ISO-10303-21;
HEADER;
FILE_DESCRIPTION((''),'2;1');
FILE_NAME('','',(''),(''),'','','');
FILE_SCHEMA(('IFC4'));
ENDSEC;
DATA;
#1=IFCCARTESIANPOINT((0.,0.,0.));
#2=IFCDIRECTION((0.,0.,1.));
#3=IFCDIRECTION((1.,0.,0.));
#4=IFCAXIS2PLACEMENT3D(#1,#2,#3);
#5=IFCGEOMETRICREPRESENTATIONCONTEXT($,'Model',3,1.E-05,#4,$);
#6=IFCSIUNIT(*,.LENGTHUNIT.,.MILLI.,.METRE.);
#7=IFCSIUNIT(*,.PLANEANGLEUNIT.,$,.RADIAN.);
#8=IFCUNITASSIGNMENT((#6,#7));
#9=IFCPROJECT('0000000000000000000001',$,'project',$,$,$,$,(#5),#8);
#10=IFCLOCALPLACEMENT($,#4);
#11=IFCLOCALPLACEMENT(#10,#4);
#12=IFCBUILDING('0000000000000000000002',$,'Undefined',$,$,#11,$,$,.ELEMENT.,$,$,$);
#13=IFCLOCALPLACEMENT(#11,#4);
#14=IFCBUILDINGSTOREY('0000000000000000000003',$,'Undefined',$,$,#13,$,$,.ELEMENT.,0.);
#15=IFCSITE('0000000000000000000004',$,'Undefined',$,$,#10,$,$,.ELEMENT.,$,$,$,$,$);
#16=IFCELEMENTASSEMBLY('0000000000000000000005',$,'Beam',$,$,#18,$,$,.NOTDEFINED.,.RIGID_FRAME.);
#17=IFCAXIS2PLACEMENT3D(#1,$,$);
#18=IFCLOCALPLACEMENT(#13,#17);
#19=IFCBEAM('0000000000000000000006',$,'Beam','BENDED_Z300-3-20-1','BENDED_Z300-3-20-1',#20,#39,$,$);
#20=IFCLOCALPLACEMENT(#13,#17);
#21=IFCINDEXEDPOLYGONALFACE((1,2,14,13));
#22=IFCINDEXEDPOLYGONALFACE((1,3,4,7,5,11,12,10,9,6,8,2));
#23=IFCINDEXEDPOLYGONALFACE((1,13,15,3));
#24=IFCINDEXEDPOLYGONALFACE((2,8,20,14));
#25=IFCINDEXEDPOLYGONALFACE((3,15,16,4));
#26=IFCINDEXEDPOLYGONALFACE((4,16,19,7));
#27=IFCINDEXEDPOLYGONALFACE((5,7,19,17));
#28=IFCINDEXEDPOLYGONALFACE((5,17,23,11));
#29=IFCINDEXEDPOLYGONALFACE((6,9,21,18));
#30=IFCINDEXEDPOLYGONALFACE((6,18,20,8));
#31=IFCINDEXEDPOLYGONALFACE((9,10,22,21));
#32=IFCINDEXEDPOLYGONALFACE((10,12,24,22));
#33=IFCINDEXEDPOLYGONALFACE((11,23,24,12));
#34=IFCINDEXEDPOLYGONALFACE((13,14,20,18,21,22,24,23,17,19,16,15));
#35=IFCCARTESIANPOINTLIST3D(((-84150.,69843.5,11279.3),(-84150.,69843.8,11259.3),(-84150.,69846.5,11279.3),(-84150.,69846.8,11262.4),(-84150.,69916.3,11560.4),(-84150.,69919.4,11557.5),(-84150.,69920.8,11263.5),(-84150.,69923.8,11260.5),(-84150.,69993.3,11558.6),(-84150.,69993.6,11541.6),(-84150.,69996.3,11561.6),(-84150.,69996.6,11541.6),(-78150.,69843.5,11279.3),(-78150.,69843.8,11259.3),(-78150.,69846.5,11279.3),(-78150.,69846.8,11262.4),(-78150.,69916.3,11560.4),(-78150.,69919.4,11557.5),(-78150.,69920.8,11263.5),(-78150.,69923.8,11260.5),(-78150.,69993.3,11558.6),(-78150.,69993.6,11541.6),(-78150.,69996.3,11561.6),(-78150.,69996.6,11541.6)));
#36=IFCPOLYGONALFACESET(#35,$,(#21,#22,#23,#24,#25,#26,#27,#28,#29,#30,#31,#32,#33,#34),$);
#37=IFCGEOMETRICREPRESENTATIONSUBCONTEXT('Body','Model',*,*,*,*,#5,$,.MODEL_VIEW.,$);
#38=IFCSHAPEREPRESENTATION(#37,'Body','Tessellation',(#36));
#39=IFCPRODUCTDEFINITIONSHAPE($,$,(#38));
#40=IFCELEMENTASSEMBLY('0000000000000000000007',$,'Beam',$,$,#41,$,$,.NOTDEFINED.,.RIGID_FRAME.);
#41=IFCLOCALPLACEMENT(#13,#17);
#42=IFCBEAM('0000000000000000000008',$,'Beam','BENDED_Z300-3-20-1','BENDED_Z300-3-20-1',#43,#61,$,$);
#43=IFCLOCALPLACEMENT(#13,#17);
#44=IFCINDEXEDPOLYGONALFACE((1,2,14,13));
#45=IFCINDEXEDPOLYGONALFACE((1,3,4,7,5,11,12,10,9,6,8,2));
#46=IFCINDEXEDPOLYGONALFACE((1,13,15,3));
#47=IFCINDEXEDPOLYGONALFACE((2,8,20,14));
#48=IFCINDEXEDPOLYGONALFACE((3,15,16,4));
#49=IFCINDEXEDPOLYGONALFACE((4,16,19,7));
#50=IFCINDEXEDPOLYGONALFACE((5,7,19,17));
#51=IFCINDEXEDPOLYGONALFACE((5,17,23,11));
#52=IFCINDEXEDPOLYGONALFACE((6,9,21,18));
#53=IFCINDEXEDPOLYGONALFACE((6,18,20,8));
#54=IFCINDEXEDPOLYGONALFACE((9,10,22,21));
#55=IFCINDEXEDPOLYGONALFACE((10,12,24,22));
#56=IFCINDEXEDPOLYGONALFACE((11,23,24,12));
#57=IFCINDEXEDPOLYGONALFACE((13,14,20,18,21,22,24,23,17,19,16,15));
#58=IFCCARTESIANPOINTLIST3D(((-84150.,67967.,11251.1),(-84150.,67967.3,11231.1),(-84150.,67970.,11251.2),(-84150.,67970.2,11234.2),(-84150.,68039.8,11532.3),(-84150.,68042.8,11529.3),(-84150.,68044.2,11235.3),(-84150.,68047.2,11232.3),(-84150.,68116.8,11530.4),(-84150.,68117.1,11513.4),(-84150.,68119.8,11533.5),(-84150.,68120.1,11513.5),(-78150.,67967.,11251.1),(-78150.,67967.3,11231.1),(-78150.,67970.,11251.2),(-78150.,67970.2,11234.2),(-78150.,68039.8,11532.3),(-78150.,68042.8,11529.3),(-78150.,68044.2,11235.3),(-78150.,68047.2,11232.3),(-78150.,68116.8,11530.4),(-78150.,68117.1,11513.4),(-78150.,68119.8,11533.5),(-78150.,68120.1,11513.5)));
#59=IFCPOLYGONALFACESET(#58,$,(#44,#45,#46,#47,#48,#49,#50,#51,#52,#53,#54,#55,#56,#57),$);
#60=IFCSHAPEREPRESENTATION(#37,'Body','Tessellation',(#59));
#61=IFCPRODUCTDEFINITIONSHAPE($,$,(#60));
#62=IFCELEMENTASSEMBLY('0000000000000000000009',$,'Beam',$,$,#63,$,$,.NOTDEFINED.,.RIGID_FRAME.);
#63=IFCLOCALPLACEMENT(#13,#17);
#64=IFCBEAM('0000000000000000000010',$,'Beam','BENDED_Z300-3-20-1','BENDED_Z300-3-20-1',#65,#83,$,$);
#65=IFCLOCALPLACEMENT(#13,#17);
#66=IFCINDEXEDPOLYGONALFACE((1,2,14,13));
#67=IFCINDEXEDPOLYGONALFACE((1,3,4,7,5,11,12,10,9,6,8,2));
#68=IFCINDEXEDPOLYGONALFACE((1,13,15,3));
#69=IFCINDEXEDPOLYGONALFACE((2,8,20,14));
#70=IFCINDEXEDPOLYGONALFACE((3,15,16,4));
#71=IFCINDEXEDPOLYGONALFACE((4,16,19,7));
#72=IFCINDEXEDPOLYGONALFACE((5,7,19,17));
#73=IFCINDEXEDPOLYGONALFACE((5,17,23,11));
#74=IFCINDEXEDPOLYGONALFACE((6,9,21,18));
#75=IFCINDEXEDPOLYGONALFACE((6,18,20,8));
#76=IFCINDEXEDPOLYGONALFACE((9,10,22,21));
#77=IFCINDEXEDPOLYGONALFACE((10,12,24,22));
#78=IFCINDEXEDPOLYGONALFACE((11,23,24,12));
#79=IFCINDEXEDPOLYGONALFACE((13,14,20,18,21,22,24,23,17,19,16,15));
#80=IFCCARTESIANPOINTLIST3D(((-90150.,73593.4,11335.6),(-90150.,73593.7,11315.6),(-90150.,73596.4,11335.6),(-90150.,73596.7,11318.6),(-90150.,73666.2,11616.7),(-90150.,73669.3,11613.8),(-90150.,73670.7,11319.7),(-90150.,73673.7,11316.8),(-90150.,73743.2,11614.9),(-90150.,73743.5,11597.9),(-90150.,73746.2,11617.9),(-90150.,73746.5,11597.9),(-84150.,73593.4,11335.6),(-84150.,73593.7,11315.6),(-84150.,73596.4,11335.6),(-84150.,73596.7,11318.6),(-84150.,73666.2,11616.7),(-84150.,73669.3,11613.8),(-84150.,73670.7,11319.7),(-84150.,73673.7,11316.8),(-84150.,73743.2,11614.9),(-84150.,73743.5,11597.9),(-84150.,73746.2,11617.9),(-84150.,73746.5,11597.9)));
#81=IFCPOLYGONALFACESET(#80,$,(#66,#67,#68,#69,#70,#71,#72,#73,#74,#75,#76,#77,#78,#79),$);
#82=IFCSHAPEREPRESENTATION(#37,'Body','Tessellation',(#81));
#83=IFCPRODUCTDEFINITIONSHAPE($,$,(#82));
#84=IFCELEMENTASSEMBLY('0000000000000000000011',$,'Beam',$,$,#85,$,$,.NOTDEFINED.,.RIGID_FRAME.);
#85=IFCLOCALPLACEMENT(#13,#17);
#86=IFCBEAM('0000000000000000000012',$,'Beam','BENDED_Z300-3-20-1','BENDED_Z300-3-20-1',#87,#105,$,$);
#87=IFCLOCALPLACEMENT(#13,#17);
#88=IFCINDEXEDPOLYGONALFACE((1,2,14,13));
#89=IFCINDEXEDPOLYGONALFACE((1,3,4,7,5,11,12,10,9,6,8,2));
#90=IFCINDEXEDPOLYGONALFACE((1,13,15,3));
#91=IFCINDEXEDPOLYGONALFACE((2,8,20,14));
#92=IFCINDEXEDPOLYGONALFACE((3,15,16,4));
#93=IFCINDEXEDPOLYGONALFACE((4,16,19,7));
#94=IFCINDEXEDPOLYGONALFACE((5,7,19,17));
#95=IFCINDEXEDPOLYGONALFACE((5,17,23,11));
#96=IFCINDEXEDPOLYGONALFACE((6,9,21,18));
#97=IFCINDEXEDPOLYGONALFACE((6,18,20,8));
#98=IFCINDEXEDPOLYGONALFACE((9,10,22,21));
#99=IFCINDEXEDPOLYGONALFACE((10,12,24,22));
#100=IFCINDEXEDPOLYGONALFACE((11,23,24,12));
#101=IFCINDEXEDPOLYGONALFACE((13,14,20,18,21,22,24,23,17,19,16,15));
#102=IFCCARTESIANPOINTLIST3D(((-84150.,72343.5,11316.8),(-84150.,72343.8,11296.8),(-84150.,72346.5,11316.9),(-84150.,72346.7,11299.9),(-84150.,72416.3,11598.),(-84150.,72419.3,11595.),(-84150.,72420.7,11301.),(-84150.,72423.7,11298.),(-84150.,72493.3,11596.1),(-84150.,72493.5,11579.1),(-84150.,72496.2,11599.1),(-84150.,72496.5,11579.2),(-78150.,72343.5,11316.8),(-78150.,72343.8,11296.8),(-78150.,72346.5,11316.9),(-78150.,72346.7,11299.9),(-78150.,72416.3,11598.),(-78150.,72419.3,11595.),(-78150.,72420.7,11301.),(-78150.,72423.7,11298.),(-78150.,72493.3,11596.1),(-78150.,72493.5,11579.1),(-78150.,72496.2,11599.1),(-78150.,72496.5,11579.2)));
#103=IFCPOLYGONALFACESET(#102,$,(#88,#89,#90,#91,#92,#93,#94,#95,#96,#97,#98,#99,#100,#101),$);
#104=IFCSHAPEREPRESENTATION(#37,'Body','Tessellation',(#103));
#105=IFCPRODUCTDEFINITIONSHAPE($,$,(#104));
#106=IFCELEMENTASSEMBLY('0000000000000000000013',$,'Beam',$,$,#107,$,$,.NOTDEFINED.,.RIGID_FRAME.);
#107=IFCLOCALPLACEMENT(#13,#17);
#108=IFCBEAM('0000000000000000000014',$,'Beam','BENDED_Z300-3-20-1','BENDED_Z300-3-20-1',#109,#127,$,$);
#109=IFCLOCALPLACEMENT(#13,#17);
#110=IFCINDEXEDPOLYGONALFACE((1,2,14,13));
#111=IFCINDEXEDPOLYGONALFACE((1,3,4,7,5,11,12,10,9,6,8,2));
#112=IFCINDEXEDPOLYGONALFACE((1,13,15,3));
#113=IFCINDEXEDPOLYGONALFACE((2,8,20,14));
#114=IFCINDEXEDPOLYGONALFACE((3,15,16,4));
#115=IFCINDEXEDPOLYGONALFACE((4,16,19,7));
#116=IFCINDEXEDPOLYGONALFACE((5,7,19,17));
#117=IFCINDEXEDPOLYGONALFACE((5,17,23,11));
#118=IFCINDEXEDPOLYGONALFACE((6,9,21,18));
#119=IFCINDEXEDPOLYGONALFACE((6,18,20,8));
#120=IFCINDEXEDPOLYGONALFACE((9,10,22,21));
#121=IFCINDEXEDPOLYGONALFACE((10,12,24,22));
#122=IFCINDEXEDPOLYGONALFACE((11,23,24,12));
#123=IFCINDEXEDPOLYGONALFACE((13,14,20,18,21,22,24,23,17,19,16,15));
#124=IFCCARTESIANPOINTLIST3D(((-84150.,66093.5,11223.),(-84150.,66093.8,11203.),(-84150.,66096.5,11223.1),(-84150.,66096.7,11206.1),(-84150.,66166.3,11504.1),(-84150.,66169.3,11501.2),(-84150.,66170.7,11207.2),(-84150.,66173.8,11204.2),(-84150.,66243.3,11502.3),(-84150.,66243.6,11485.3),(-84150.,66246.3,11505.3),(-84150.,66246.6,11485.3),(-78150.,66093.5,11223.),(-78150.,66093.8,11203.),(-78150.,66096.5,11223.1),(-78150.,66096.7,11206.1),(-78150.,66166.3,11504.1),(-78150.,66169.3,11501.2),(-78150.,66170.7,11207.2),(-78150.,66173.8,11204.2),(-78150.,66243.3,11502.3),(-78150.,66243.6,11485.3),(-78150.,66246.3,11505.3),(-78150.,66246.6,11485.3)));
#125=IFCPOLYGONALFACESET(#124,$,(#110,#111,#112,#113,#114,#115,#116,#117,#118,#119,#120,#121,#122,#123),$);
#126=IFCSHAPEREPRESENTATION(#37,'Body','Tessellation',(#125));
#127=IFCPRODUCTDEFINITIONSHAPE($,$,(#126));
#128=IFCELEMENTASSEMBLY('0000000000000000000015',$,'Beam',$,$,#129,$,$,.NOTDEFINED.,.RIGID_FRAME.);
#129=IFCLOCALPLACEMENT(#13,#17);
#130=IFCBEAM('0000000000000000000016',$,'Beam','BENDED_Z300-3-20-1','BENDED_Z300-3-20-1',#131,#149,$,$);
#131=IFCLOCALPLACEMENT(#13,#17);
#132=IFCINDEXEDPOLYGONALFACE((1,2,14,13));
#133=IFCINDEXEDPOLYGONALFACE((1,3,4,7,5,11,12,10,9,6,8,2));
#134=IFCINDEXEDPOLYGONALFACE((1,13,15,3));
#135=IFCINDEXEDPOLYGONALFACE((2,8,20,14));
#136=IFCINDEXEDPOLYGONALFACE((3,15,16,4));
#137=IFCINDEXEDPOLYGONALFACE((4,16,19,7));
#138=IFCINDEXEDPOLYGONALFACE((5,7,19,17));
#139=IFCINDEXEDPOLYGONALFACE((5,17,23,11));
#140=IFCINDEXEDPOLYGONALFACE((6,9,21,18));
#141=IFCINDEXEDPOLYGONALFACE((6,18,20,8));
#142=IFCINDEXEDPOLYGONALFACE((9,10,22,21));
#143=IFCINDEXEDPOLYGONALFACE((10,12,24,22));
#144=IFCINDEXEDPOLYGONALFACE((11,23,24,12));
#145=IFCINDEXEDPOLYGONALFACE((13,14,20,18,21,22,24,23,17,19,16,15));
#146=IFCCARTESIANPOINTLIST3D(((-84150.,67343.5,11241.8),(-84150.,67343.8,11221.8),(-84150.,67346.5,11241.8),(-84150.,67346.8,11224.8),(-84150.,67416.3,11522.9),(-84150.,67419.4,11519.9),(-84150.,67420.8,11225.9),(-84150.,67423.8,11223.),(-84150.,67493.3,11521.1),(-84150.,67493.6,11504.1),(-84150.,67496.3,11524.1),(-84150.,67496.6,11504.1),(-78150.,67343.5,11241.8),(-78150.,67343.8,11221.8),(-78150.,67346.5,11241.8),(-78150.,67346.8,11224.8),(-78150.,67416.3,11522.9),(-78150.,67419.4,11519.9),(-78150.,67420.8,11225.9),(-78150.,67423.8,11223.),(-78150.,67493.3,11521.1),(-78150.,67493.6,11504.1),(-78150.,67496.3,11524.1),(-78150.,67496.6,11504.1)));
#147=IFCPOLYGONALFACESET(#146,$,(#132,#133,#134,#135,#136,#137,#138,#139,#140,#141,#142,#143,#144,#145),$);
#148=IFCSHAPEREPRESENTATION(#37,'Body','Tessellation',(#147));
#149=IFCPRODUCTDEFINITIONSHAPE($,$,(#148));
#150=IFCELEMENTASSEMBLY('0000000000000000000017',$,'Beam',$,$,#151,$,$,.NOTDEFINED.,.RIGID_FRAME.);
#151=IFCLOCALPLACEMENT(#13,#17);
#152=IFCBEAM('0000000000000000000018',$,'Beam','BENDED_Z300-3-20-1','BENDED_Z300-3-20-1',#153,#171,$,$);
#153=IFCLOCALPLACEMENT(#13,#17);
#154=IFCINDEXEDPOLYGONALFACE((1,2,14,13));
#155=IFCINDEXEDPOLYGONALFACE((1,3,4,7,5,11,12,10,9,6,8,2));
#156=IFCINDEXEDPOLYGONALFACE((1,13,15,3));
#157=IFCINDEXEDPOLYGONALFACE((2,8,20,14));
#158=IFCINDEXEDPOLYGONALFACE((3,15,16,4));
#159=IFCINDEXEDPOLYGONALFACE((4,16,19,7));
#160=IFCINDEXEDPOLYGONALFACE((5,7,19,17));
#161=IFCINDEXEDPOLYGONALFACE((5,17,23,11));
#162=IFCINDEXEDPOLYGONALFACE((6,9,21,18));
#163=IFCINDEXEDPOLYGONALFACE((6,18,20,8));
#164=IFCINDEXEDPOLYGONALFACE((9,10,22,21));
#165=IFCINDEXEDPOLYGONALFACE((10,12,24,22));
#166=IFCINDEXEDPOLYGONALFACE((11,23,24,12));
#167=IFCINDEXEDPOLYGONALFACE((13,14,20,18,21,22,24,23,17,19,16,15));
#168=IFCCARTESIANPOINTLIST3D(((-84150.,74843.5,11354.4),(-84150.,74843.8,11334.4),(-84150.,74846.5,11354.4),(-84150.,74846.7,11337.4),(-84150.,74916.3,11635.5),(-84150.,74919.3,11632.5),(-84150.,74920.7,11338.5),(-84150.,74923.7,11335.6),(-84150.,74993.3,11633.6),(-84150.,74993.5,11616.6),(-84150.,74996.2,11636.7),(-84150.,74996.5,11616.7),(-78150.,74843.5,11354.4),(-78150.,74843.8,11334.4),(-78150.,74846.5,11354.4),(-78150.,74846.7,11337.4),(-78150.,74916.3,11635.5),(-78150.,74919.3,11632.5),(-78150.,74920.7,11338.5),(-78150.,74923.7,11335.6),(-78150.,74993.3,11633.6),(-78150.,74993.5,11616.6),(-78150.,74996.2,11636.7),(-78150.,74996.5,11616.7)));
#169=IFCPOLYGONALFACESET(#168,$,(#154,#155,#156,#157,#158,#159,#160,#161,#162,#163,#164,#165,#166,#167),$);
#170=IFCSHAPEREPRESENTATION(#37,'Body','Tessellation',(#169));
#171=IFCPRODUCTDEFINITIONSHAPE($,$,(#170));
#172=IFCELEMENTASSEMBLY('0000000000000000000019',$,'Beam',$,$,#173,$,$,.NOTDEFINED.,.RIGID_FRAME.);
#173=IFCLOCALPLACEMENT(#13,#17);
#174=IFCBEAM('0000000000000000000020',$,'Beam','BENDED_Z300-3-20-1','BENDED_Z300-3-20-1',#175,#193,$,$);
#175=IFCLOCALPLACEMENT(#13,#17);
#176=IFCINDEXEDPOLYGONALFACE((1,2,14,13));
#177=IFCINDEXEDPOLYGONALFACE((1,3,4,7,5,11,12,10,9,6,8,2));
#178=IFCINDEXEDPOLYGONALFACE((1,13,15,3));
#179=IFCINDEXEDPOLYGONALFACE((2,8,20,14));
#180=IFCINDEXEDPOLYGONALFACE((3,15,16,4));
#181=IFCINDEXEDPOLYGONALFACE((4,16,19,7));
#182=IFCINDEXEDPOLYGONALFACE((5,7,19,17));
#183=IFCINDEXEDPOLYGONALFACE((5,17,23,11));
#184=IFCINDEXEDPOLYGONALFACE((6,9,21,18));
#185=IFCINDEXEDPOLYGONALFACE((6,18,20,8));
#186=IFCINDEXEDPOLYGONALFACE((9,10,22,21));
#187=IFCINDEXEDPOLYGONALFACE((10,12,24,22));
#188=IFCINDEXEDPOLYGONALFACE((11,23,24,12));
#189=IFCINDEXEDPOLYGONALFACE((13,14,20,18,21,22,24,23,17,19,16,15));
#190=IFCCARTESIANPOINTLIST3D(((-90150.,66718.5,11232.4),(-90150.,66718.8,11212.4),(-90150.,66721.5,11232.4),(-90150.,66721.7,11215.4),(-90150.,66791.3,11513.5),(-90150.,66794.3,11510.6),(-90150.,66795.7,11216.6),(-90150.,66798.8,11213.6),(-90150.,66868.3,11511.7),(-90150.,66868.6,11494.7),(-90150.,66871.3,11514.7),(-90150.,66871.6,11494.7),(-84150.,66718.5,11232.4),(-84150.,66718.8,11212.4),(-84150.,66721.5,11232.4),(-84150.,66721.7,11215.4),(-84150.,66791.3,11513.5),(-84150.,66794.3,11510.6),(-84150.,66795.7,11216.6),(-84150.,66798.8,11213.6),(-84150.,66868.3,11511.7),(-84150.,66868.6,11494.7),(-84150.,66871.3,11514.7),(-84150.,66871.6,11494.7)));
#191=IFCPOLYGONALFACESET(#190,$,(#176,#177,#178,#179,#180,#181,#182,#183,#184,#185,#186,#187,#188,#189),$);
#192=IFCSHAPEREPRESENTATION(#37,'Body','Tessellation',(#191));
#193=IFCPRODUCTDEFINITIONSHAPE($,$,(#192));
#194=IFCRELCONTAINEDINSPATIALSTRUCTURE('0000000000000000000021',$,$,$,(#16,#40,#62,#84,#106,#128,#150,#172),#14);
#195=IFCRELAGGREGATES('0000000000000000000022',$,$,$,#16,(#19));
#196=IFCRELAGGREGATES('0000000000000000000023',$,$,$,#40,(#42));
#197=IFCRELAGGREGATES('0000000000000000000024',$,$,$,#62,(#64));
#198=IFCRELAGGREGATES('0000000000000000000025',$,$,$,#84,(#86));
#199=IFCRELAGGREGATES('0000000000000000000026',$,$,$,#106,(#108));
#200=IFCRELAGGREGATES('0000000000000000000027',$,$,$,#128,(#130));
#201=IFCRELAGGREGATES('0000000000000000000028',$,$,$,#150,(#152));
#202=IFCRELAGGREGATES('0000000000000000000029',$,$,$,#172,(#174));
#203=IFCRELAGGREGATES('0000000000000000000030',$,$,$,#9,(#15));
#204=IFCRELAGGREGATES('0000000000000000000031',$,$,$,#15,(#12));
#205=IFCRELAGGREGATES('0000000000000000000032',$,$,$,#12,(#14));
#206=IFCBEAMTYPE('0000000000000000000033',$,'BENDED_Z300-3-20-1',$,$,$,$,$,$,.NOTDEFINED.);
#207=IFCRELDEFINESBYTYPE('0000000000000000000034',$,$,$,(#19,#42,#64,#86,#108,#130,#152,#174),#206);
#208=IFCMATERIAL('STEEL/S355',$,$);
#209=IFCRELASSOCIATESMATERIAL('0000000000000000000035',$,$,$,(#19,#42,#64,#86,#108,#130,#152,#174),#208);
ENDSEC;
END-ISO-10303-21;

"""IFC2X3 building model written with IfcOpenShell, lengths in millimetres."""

from ifc_helpers import new_model, si_unit, frame, origin_with_axes, place, context, subcontext, project, spatial, polyline, outline, extrude, material, type_object, element, aggregate, save


model = new_model("IFC2X3")

# Units and contexts
model_context = context("Model", 3, precision=1e-05, world=origin_with_axes())
body_context = subcontext(model_context, "Body", "Model", "MODEL_VIEW")
ifc_project = project(units=[si_unit("LENGTHUNIT", "METRE", prefix="MILLI"), si_unit("PLANEANGLEUNIT", "RADIAN")], contexts=[model_context])

# Site, building, storey
site_placement = place(None, origin_with_axes())
site = spatial("IfcSite", under=ifc_project, at=site_placement, Name="Undefined", CompositionType="ELEMENT")
building_placement = place(site_placement, origin_with_axes())
building = spatial("IfcBuilding", under=site, at=building_placement, Name="Undefined", CompositionType="ELEMENT")
storey_placement = place(building_placement, origin_with_axes())
storey = spatial("IfcBuildingStorey", under=building, at=storey_placement, Name="Undefined", CompositionType="ELEMENT", Elevation=0.0)

# Shared definitions
ifc_material_1 = material(Name="STEEL/S355")

# Element assemblies, beams
beam_type_1 = type_object("IfcBeamType", Name="BENDED_Z300-3-20-1", PredefinedType="NOTDEFINED")
assembly_1_placement = place(storey_placement, origin_with_axes())
assembly_1 = element("IfcElementAssembly", 1, at=assembly_1_placement, inside=storey, Name="Beam", AssemblyPlace="NOTDEFINED", PredefinedType="RIGID_FRAME")
beam_1_placement = place(assembly_1_placement, frame((-78150.0, 69920.1, 11410.5), z_axis=(0.0, -0.014963, 0.999888), x_axis=(-1.0, 0.0, 0.0)))
beam_1 = element("IfcBeam", 2, at=beam_1_placement, type_object=beam_type_1, material=ifc_material_1, Name="Beam", Description="BENDED_Z300-3-20-1", ObjectType="BENDED_Z300-3-20-1", context=body_context, shape_type="SweptSolid", body=[
    extrude(outline(polyline([(1.5, -150.0), (-78.5, -150.0), (-78.5, -130.0), (-75.5, -130.0), (-75.5, -147.0), (-1.5, -147.0), (-1.5, 150.0), (78.5, 150.0), (78.5, 130.0), (75.5, 130.0), (75.5, 147.0), (1.5, 147.0), (1.5, -150.0)])), frame((6000.0, 0.0, 0.0), z_axis=(-1.0, 0.0, 0.0), x_axis=(0.0, -1.0, 0.0)), (0.0, 0.0, 1.0), 6000.0),
])
aggregate(assembly_1, [beam_1])
assembly_2_placement = place(storey_placement, origin_with_axes())
assembly_2 = element("IfcElementAssembly", 3, at=assembly_2_placement, inside=storey, Name="Beam", AssemblyPlace="NOTDEFINED", PredefinedType="RIGID_FRAME")
beam_2_placement = place(assembly_2_placement, frame((-78150.0, 68043.5, 11382.3), z_axis=(0.0, -0.014963, 0.999888), x_axis=(-1.0, 0.0, 0.0)))
beam_2 = element("IfcBeam", 4, at=beam_2_placement, type_object=beam_type_1, material=ifc_material_1, Name="Beam", Description="BENDED_Z300-3-20-1", ObjectType="BENDED_Z300-3-20-1", context=body_context, shape_type="SweptSolid", body=[
    extrude(outline(polyline([(1.5, -150.0), (-78.5, -150.0), (-78.5, -130.0), (-75.5, -130.0), (-75.5, -147.0), (-1.5, -147.0), (-1.5, 150.0), (78.5, 150.0), (78.5, 130.0), (75.5, 130.0), (75.5, 147.0), (1.5, 147.0), (1.5, -150.0)])), frame((6000.0, 0.0, 0.0), z_axis=(-1.0, 0.0, 0.0), x_axis=(0.0, -1.0, 0.0)), (0.0, 0.0, 1.0), 6000.0),
])
aggregate(assembly_2, [beam_2])
assembly_3_placement = place(storey_placement, origin_with_axes())
assembly_3 = element("IfcElementAssembly", 5, at=assembly_3_placement, inside=storey, Name="Beam", AssemblyPlace="NOTDEFINED", PredefinedType="RIGID_FRAME")
beam_3_placement = place(assembly_3_placement, frame((-84150.0, 73670.0, 11466.8), z_axis=(0.0, -0.014963, 0.999888), x_axis=(-1.0, 0.0, 0.0)))
beam_3 = element("IfcBeam", 6, at=beam_3_placement, type_object=beam_type_1, material=ifc_material_1, Name="Beam", Description="BENDED_Z300-3-20-1", ObjectType="BENDED_Z300-3-20-1", context=body_context, shape_type="SweptSolid", body=[
    extrude(outline(polyline([(1.5, -150.0), (-78.5, -150.0), (-78.5, -130.0), (-75.5, -130.0), (-75.5, -147.0), (-1.5, -147.0), (-1.5, 150.0), (78.5, 150.0), (78.5, 130.0), (75.5, 130.0), (75.5, 147.0), (1.5, 147.0), (1.5, -150.0)])), frame((6000.0, 0.0, 0.0), z_axis=(-1.0, 0.0, 0.0), x_axis=(0.0, -1.0, 0.0)), (0.0, 0.0, 1.0), 6000.0),
])
aggregate(assembly_3, [beam_3])
assembly_4_placement = place(storey_placement, origin_with_axes())
assembly_4 = element("IfcElementAssembly", 7, at=assembly_4_placement, inside=storey, Name="Beam", AssemblyPlace="NOTDEFINED", PredefinedType="RIGID_FRAME")
beam_4_placement = place(assembly_4_placement, frame((-78150.0, 72420.0, 11448.0), z_axis=(0.0, -0.014963, 0.999888), x_axis=(-1.0, 0.0, 0.0)))
beam_4 = element("IfcBeam", 8, at=beam_4_placement, type_object=beam_type_1, material=ifc_material_1, Name="Beam", Description="BENDED_Z300-3-20-1", ObjectType="BENDED_Z300-3-20-1", context=body_context, shape_type="SweptSolid", body=[
    extrude(outline(polyline([(1.5, -150.0), (-78.5, -150.0), (-78.5, -130.0), (-75.5, -130.0), (-75.5, -147.0), (-1.5, -147.0), (-1.5, 150.0), (78.5, 150.0), (78.5, 130.0), (75.5, 130.0), (75.5, 147.0), (1.5, 147.0), (1.5, -150.0)])), frame((6000.0, 0.0, 0.0), z_axis=(-1.0, 0.0, 0.0), x_axis=(0.0, -1.0, 0.0)), (0.0, 0.0, 1.0), 6000.0),
])
aggregate(assembly_4, [beam_4])
assembly_5_placement = place(storey_placement, origin_with_axes())
assembly_5 = element("IfcElementAssembly", 9, at=assembly_5_placement, inside=storey, Name="Beam", AssemblyPlace="NOTDEFINED", PredefinedType="RIGID_FRAME")
beam_5_placement = place(assembly_5_placement, frame((-78150.0, 66170.0, 11354.2), z_axis=(0.0, -0.014963, 0.999888), x_axis=(-1.0, 0.0, 0.0)))
beam_5 = element("IfcBeam", 10, at=beam_5_placement, type_object=beam_type_1, material=ifc_material_1, Name="Beam", Description="BENDED_Z300-3-20-1", ObjectType="BENDED_Z300-3-20-1", context=body_context, shape_type="SweptSolid", body=[
    extrude(outline(polyline([(1.5, -150.0), (-78.5, -150.0), (-78.5, -130.0), (-75.5, -130.0), (-75.5, -147.0), (-1.5, -147.0), (-1.5, 150.0), (78.5, 150.0), (78.5, 130.0), (75.5, 130.0), (75.5, 147.0), (1.5, 147.0), (1.5, -150.0)])), frame((6000.0, 0.0, 0.0), z_axis=(-1.0, 0.0, 0.0), x_axis=(0.0, -1.0, 0.0)), (0.0, 0.0, 1.0), 6000.0),
])
aggregate(assembly_5, [beam_5])
assembly_6_placement = place(storey_placement, origin_with_axes())
assembly_6 = element("IfcElementAssembly", 11, at=assembly_6_placement, inside=storey, Name="Beam", AssemblyPlace="NOTDEFINED", PredefinedType="RIGID_FRAME")
beam_6_placement = place(assembly_6_placement, frame((-78150.0, 67420.1, 11372.9), z_axis=(0.0, -0.014963, 0.999888), x_axis=(-1.0, 0.0, 0.0)))
beam_6 = element("IfcBeam", 12, at=beam_6_placement, type_object=beam_type_1, material=ifc_material_1, Name="Beam", Description="BENDED_Z300-3-20-1", ObjectType="BENDED_Z300-3-20-1", context=body_context, shape_type="SweptSolid", body=[
    extrude(outline(polyline([(1.5, -150.0), (-78.5, -150.0), (-78.5, -130.0), (-75.5, -130.0), (-75.5, -147.0), (-1.5, -147.0), (-1.5, 150.0), (78.5, 150.0), (78.5, 130.0), (75.5, 130.0), (75.5, 147.0), (1.5, 147.0), (1.5, -150.0)])), frame((6000.0, 0.0, 0.0), z_axis=(-1.0, 0.0, 0.0), x_axis=(0.0, -1.0, 0.0)), (0.0, 0.0, 1.0), 6000.0),
])
aggregate(assembly_6, [beam_6])
assembly_7_placement = place(storey_placement, origin_with_axes())
assembly_7 = element("IfcElementAssembly", 13, at=assembly_7_placement, inside=storey, Name="Beam", AssemblyPlace="NOTDEFINED", PredefinedType="RIGID_FRAME")
beam_7_placement = place(assembly_7_placement, frame((-78150.0, 74920.0, 11485.5), z_axis=(0.0, -0.014963, 0.999888), x_axis=(-1.0, 0.0, 0.0)))
beam_7 = element("IfcBeam", 14, at=beam_7_placement, type_object=beam_type_1, material=ifc_material_1, Name="Beam", Description="BENDED_Z300-3-20-1", ObjectType="BENDED_Z300-3-20-1", context=body_context, shape_type="SweptSolid", body=[
    extrude(outline(polyline([(1.5, -150.0), (-78.5, -150.0), (-78.5, -130.0), (-75.5, -130.0), (-75.5, -147.0), (-1.5, -147.0), (-1.5, 150.0), (78.5, 150.0), (78.5, 130.0), (75.5, 130.0), (75.5, 147.0), (1.5, 147.0), (1.5, -150.0)])), frame((6000.0, 0.0, 0.0), z_axis=(-1.0, 0.0, 0.0), x_axis=(0.0, -1.0, 0.0)), (0.0, 0.0, 1.0), 6000.0),
])
aggregate(assembly_7, [beam_7])
assembly_8_placement = place(storey_placement, origin_with_axes())
assembly_8 = element("IfcElementAssembly", 15, at=assembly_8_placement, inside=storey, Name="Beam", AssemblyPlace="NOTDEFINED", PredefinedType="RIGID_FRAME")
beam_8_placement = place(assembly_8_placement, frame((-84150.0, 66795.0, 11363.6), z_axis=(0.0, -0.014963, 0.999888), x_axis=(-1.0, 0.0, 0.0)))
beam_8 = element("IfcBeam", 16, at=beam_8_placement, type_object=beam_type_1, material=ifc_material_1, Name="Beam", Description="BENDED_Z300-3-20-1", ObjectType="BENDED_Z300-3-20-1", context=body_context, shape_type="SweptSolid", body=[
    extrude(outline(polyline([(1.5, -150.0), (-78.5, -150.0), (-78.5, -130.0), (-75.5, -130.0), (-75.5, -147.0), (-1.5, -147.0), (-1.5, 150.0), (78.5, 150.0), (78.5, 130.0), (75.5, 130.0), (75.5, 147.0), (1.5, 147.0), (1.5, -150.0)])), frame((6000.0, 0.0, 0.0), z_axis=(-1.0, 0.0, 0.0), x_axis=(0.0, -1.0, 0.0)), (0.0, 0.0, 1.0), 6000.0),
])
aggregate(assembly_8, [beam_8])

save(model, "model.ifc")
